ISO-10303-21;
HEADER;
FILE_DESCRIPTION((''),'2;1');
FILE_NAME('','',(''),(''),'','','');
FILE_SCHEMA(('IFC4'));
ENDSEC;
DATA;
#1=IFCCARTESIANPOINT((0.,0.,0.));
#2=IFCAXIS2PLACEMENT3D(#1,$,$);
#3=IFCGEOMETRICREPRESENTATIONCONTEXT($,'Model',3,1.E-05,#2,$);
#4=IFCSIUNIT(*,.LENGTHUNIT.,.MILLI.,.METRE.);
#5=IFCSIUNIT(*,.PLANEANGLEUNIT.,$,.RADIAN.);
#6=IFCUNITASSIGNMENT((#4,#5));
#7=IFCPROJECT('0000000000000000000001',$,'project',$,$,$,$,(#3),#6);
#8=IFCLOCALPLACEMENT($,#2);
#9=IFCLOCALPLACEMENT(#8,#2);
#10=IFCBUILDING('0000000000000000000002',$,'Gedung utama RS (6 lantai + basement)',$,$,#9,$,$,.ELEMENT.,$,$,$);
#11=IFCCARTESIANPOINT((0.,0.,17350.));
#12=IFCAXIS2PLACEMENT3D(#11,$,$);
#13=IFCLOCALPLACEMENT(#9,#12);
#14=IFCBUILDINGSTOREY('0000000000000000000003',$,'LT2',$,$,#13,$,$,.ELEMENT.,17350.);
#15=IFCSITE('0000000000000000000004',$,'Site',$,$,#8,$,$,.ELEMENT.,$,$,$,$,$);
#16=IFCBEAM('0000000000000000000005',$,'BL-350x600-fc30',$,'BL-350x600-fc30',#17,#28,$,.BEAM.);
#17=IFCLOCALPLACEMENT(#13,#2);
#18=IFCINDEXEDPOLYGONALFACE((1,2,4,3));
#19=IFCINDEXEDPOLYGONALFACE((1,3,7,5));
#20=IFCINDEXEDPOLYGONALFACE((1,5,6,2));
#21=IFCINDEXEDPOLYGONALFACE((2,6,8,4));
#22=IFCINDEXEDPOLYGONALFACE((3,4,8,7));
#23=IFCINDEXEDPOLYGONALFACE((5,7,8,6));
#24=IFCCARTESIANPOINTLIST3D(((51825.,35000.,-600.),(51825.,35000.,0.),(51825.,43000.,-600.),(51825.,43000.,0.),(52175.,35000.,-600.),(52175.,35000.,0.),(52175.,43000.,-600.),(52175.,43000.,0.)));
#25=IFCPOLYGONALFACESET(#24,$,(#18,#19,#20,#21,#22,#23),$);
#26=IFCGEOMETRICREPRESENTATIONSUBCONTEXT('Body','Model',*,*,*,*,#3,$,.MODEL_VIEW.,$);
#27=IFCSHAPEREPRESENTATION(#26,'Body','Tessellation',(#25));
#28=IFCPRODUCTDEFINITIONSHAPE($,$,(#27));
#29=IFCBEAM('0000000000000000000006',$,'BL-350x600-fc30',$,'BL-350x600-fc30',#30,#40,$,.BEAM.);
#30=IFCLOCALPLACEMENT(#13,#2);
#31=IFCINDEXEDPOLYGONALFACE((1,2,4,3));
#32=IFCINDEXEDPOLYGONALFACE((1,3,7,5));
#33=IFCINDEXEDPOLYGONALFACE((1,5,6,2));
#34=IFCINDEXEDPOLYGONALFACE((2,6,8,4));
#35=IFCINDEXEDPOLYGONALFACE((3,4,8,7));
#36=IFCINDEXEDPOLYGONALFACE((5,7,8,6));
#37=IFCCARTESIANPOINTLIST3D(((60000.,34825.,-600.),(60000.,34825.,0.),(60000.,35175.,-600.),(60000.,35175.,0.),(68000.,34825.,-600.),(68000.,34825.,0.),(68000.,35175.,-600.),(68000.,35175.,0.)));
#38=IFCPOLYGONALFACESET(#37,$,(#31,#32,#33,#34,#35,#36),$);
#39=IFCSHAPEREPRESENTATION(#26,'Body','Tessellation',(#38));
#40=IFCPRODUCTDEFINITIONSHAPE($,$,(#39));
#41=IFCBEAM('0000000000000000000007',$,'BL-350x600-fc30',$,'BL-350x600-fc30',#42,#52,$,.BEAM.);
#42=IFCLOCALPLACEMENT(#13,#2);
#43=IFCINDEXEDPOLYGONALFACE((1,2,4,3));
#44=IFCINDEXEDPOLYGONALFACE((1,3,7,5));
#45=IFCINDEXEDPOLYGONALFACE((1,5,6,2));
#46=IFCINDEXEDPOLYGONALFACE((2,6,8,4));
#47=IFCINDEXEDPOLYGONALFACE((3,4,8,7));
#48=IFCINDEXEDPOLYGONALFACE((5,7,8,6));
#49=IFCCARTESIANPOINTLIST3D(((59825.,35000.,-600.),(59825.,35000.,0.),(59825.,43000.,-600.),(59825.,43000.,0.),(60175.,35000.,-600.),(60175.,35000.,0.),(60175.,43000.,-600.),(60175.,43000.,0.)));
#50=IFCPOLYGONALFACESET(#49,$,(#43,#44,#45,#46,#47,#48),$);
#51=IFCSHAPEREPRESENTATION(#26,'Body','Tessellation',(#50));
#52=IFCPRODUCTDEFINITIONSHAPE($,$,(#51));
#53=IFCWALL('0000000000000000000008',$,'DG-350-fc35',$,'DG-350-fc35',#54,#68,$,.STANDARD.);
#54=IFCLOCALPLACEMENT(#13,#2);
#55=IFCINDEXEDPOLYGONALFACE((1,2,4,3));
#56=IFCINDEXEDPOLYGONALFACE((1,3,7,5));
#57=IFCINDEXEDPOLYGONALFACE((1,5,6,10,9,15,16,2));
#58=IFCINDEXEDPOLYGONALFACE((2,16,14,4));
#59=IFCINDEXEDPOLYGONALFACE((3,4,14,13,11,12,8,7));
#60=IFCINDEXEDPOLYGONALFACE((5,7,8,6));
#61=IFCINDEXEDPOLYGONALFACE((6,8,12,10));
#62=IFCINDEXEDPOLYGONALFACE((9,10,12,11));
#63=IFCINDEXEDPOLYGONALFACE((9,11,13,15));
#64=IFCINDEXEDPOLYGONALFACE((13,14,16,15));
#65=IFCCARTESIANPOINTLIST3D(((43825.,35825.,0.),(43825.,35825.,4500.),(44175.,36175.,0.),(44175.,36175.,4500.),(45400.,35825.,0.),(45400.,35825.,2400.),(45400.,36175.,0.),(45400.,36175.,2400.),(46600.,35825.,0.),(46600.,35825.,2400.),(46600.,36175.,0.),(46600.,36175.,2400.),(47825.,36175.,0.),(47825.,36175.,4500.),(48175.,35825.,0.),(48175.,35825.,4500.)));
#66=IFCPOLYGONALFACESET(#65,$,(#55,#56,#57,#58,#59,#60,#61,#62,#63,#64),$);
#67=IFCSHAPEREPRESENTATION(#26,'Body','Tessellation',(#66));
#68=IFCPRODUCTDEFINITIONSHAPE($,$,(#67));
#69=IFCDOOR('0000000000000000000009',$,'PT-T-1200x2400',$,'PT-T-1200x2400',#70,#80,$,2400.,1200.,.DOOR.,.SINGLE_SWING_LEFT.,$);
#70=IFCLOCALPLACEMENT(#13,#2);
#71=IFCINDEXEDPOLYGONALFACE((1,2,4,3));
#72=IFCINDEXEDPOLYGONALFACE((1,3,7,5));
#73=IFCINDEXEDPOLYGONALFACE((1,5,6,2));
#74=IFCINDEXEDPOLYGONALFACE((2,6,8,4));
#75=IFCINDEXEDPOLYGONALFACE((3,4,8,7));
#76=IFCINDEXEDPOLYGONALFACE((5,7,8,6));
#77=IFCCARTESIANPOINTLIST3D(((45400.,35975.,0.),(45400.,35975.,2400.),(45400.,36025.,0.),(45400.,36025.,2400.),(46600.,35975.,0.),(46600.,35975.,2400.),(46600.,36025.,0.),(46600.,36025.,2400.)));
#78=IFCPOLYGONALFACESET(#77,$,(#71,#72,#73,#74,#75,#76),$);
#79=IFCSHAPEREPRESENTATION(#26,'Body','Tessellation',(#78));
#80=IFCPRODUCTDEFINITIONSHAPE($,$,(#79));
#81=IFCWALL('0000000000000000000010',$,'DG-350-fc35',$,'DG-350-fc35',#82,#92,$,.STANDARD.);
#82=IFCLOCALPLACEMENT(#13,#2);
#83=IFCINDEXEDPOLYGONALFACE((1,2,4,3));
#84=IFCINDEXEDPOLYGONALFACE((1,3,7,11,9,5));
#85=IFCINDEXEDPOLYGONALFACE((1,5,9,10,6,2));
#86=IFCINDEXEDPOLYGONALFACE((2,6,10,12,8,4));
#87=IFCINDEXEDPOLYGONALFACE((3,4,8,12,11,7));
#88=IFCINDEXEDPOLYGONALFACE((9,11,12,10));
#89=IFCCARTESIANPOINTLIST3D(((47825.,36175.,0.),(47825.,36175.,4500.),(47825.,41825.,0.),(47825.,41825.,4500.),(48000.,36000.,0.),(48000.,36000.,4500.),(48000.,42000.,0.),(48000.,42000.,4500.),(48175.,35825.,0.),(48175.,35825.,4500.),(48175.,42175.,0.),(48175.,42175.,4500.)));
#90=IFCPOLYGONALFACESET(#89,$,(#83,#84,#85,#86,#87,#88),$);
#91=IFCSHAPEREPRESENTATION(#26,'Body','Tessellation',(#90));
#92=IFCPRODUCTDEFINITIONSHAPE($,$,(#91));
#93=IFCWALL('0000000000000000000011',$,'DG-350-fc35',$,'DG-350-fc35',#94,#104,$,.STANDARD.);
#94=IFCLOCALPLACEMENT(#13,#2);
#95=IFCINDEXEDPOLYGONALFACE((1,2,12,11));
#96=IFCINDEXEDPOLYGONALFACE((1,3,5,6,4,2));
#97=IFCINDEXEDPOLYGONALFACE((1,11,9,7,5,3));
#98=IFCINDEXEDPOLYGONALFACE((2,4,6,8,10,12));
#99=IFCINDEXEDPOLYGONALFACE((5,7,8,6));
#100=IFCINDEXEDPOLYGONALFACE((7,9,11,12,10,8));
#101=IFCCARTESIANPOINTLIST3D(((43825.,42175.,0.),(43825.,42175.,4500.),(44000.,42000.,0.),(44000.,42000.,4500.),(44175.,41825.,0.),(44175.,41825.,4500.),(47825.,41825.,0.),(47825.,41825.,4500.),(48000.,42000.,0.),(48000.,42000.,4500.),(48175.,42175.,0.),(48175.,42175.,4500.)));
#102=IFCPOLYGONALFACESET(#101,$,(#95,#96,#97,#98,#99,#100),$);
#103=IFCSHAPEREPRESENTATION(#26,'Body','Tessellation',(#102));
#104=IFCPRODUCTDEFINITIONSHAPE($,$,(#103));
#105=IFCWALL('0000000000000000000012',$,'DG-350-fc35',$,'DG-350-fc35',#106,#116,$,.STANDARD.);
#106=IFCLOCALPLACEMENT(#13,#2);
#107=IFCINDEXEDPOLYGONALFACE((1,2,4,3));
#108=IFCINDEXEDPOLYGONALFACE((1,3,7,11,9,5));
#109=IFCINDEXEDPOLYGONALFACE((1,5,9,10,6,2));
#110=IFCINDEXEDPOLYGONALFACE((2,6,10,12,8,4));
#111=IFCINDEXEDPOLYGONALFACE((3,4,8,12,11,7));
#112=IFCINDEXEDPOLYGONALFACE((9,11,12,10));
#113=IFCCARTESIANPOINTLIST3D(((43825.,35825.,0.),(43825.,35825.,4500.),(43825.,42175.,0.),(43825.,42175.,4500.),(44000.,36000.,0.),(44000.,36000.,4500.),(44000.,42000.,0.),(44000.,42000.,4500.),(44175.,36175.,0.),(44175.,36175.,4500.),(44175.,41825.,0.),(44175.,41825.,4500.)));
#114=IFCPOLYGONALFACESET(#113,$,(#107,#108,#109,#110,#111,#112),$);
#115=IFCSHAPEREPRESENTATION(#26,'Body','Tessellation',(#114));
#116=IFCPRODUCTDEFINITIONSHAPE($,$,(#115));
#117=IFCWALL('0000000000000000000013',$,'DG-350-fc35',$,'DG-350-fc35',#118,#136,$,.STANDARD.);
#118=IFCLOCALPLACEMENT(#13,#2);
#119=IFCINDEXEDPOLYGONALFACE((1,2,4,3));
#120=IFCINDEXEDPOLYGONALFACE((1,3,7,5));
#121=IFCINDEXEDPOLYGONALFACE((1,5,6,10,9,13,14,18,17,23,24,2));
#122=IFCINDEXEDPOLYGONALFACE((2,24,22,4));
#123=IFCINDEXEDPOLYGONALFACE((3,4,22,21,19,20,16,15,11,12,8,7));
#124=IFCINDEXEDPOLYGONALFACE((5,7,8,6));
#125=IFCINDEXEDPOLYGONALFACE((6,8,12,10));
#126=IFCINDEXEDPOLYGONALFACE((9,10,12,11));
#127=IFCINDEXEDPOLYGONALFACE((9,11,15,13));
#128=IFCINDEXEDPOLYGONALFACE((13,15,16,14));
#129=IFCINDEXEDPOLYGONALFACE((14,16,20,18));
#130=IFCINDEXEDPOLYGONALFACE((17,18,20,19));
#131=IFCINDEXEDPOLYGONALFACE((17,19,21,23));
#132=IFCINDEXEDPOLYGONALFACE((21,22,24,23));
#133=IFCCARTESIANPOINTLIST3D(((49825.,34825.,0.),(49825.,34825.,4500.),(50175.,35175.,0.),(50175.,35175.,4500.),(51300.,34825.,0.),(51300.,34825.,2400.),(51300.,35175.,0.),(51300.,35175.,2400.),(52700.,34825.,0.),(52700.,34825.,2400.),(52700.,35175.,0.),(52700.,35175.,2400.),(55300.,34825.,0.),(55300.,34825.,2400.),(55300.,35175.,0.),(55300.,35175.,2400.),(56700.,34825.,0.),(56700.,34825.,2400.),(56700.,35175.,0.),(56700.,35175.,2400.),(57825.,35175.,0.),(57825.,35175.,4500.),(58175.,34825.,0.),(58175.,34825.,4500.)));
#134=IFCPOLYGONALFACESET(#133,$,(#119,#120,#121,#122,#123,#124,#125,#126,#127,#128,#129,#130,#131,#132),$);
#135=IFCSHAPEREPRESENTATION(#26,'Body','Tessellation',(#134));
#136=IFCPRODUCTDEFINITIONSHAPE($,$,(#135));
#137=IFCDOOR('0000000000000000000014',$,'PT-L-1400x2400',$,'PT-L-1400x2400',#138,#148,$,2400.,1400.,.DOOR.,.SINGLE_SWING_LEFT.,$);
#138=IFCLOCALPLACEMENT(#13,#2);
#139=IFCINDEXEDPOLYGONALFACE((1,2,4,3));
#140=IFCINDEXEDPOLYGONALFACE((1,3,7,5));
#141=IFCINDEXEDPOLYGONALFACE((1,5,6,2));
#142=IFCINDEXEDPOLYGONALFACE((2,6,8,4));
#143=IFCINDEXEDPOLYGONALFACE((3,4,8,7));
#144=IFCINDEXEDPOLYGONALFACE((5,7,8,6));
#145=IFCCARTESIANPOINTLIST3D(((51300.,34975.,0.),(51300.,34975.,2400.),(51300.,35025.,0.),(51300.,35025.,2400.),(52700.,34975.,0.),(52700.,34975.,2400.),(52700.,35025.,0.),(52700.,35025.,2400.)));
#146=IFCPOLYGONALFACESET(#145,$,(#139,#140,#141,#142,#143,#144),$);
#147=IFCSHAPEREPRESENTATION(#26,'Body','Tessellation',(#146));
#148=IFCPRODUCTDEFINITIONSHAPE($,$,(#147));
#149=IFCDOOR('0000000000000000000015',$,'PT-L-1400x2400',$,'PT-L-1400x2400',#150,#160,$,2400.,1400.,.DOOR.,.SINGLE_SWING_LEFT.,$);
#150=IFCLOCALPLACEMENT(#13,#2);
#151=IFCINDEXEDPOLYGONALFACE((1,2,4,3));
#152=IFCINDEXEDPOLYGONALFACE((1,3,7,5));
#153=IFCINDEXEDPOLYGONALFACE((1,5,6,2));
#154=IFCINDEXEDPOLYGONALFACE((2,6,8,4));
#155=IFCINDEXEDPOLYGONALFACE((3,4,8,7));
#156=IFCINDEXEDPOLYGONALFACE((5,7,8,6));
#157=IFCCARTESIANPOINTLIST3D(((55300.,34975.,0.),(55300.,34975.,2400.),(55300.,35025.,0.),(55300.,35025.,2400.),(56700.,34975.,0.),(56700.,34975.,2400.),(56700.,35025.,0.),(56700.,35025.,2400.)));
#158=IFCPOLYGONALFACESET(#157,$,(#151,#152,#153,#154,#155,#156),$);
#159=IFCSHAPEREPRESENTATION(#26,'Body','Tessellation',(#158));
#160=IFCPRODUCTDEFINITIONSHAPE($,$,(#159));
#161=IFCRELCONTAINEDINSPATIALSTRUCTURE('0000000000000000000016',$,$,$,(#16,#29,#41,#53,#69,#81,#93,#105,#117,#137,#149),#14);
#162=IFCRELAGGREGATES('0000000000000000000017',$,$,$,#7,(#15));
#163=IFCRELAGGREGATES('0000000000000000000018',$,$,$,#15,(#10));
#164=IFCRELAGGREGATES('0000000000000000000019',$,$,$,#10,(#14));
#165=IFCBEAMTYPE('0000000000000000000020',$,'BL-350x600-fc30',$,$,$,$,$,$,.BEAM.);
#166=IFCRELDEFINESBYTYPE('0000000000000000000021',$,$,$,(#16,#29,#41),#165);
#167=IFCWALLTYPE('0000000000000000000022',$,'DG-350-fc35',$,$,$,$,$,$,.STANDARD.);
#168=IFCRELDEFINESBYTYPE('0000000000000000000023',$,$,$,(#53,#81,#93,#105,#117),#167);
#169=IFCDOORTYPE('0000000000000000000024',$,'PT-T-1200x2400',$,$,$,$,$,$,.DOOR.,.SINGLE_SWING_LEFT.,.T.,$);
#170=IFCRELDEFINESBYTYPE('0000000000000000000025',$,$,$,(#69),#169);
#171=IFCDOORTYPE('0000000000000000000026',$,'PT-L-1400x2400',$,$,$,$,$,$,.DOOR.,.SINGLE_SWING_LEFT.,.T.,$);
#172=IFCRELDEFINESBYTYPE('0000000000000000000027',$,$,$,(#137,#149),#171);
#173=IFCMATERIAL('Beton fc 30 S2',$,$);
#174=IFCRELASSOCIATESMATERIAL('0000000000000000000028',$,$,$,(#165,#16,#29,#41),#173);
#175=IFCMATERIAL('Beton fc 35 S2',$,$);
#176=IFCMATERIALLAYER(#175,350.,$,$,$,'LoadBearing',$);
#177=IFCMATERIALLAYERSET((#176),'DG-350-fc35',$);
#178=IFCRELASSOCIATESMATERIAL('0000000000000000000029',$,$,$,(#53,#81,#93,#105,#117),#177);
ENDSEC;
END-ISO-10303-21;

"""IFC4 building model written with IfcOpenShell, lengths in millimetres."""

from ifc_helpers import new_model, si_unit, frame, frame_2d, origin, origin_2d, place, context, subcontext, project, spatial, polyline, rectangle, outline, extrude, material, layer, layer_set, layer_usage, material_profile, profile_set, profile_usage, type_object, element, fill, save


model = new_model("IFC4")

# Units and contexts
model_context = context("Model", 3, precision=1e-05, world=origin())
body_context = subcontext(model_context, "Body", "Model", "MODEL_VIEW")
ifc_project = project(units=[si_unit("LENGTHUNIT", "METRE", prefix="MILLI"), si_unit("PLANEANGLEUNIT", "RADIAN")], contexts=[model_context])

# Site, building, storey
site_placement = place(None, origin())
site = spatial("IfcSite", under=ifc_project, at=site_placement, Name="Site", CompositionType="ELEMENT")
building_placement = place(site_placement, origin())
building = spatial("IfcBuilding", under=site, at=building_placement, Name="Gedung utama RS (6 lantai + basement)", CompositionType="ELEMENT")
storey_placement = place(building_placement, frame((0.0, 0.0, 17350.0)))
storey = spatial("IfcBuildingStorey", under=building, at=storey_placement, Name="LT2", CompositionType="ELEMENT", Elevation=17350.0)

# Beams
ifc_material_1 = material(Name="Beton fc 30 S2")
ifc_material_profile_1 = material_profile(ifc_material_1, rectangle(XDim=350.0, YDim=600.0, at=origin_2d()), Name="BL-350x600-fc30")
ifc_profile_set_1 = profile_set([ifc_material_profile_1], Name="BL-350x600-fc30")
ifc_profile_usage_1 = profile_usage(ifc_profile_set_1, cardinal=8)
beam_type = type_object("IfcBeamType", Name="BL-350x600-fc30", PredefinedType="BEAM", material=ifc_profile_set_1)
beam_1_placement = place(storey_placement, frame((52000.0, 35000.0, -300.0)))
element("IfcBeam", 1, at=beam_1_placement, inside=storey, type_object=beam_type, material=ifc_profile_usage_1, Name="BL-350x600-fc30", ObjectType="BL-350x600-fc30", PredefinedType="BEAM", context=body_context, shape_type="SweptSolid", body=[
    extrude(rectangle(XDim=350.0, YDim=600.0, at=origin_2d()), frame((0.0, 0.0, 0.0), z_axis=(0.0, 1.0, 0.0), x_axis=(-1.0, 0.0, 0.0)), (0.0, 0.0, 1.0), 8000.0),
])
beam_2_placement = place(storey_placement, frame((60000.0, 35000.0, -300.0)))
element("IfcBeam", 2, at=beam_2_placement, inside=storey, type_object=beam_type, material=ifc_profile_usage_1, Name="BL-350x600-fc30", ObjectType="BL-350x600-fc30", PredefinedType="BEAM", context=body_context, shape_type="SweptSolid", body=[
    extrude(rectangle(XDim=350.0, YDim=600.0, at=origin_2d()), frame((0.0, 0.0, 0.0), z_axis=(1.0, 0.0, 0.0), x_axis=(0.0, 1.0, 0.0)), (0.0, 0.0, 1.0), 8000.0),
])
beam_3_placement = place(storey_placement, frame((60000.0, 35000.0, -300.0)))
element("IfcBeam", 3, at=beam_3_placement, inside=storey, type_object=beam_type, material=ifc_profile_usage_1, Name="BL-350x600-fc30", ObjectType="BL-350x600-fc30", PredefinedType="BEAM", context=body_context, shape_type="SweptSolid", body=[
    extrude(rectangle(XDim=350.0, YDim=600.0, at=origin_2d()), frame((0.0, 0.0, 0.0), z_axis=(0.0, 1.0, 0.0), x_axis=(-1.0, 0.0, 0.0)), (0.0, 0.0, 1.0), 8000.0),
])

# Wall, opening, door
ifc_material_2 = material(Name="Beton fc 35 S2")
ifc_layer = layer(ifc_material_2, 350.0, Category="LoadBearing")
ifc_layer_set = layer_set([ifc_layer], Name="DG-350-fc35")
ifc_layer_usage = layer_usage(ifc_layer_set, "AXIS2", "NEGATIVE", 175.0)
wall_type = type_object("IfcWallType", Name="DG-350-fc35", PredefinedType="STANDARD")
wall_1_placement = place(storey_placement, frame((44000.0, 36000.0, 0.0), z_axis=(0.0, 0.0, 1.0), x_axis=(1.0, 0.0, 0.0)))
wall_1 = element("IfcWall", 4, at=wall_1_placement, inside=storey, type_object=wall_type, material=ifc_layer_usage, Name="DG-350-fc35", ObjectType="DG-350-fc35", PredefinedType="STANDARD", context=body_context, shape_type="SweptSolid", body=[
    extrude(outline(polyline([(-175.0, -175.0), (0.0, 0.0), (175.0, 175.0), (3825.0, 175.0), (4000.0, 0.0), (4175.0, -175.0), (-175.0, -175.0)])), origin(), (0.0, 0.0, 1.0), 4500.0),
])
opening_1_placement = place(wall_1_placement, frame((1400.0, 0.0, 0.0), z_axis=(0.0, 0.0, 1.0), x_axis=(1.0, 0.0, 0.0)))
opening_1 = element("IfcOpeningElement", 5, at=opening_1_placement, cuts=wall_1, PredefinedType="OPENING", context=body_context, shape_type="SweptSolid", body=[
    extrude(rectangle(XDim=1200.0, YDim=370.0, at=frame_2d((600.0, 0.0))), origin(), (0.0, 0.0, 1.0), 2400.0),
])
door_type_1 = type_object("IfcDoorType", Name="PT-T-1200x2400", OperationType="SINGLE_SWING_LEFT", ParameterTakesPrecedence=True, PredefinedType="DOOR")
door_1_placement = place(opening_1_placement, origin())
door_1 = element("IfcDoor", 6, at=door_1_placement, inside=storey, type_object=door_type_1, Name="PT-T-1200x2400", ObjectType="PT-T-1200x2400", OperationType="SINGLE_SWING_LEFT", OverallHeight=2400.0, OverallWidth=1200.0, PredefinedType="DOOR", context=body_context, shape_type="SweptSolid", body=[
    extrude(rectangle(XDim=1200.0, YDim=50.0, at=frame_2d((600.0, 0.0))), origin(), (0.0, 0.0, 1.0), 2400.0),
])
fill(opening_1, door_1)

# Walls
wall_2_placement = place(storey_placement, frame((48000.0, 36000.0, 0.0), z_axis=(0.0, 0.0, 1.0), x_axis=(0.0, 1.0, 0.0)))
element("IfcWall", 7, at=wall_2_placement, inside=storey, type_object=wall_type, material=ifc_layer_usage, Name="DG-350-fc35", ObjectType="DG-350-fc35", PredefinedType="STANDARD", context=body_context, shape_type="SweptSolid", body=[
    extrude(outline(polyline([(-175.0, -175.0), (0.0, 0.0), (175.0, 175.0), (5825.0, 175.0), (6000.0, 0.0), (6175.0, -175.0), (-175.0, -175.0)])), origin(), (0.0, 0.0, 1.0), 4500.0),
])
wall_3_placement = place(storey_placement, frame((48000.0, 42000.0, 0.0), z_axis=(0.0, 0.0, 1.0), x_axis=(-1.0, 0.0, 0.0)))
element("IfcWall", 8, at=wall_3_placement, inside=storey, type_object=wall_type, material=ifc_layer_usage, Name="DG-350-fc35", ObjectType="DG-350-fc35", PredefinedType="STANDARD", context=body_context, shape_type="SweptSolid", body=[
    extrude(outline(polyline([(-175.0, -175.0), (0.0, 0.0), (175.0, 175.0), (3825.0, 175.0), (4000.0, 0.0), (4175.0, -175.0), (-175.0, -175.0)])), origin(), (0.0, 0.0, 1.0), 4500.0),
])
wall_4_placement = place(storey_placement, frame((44000.0, 42000.0, 0.0), z_axis=(0.0, 0.0, 1.0), x_axis=(0.0, -1.0, 0.0)))
element("IfcWall", 9, at=wall_4_placement, inside=storey, type_object=wall_type, material=ifc_layer_usage, Name="DG-350-fc35", ObjectType="DG-350-fc35", PredefinedType="STANDARD", context=body_context, shape_type="SweptSolid", body=[
    extrude(outline(polyline([(-175.0, -175.0), (0.0, 0.0), (175.0, 175.0), (5825.0, 175.0), (6000.0, 0.0), (6175.0, -175.0), (-175.0, -175.0)])), origin(), (0.0, 0.0, 1.0), 4500.0),
])

# Wall, openings, doors
wall_5_placement = place(storey_placement, frame((50000.0, 35000.0, 0.0), z_axis=(0.0, 0.0, 1.0), x_axis=(1.0, 0.0, 0.0)))
wall_5 = element("IfcWall", 10, at=wall_5_placement, inside=storey, type_object=wall_type, material=ifc_layer_usage, Name="DG-350-fc35", ObjectType="DG-350-fc35", PredefinedType="STANDARD", context=body_context, shape_type="SweptSolid", body=[
    extrude(outline(polyline([(-175.0, -175.0), (0.0, 0.0), (175.0, 175.0), (7825.0, 175.0), (8000.0, 0.0), (8175.0, -175.0), (-175.0, -175.0)])), origin(), (0.0, 0.0, 1.0), 4500.0),
])
opening_2_placement = place(wall_5_placement, frame((1300.0, 0.0, 0.0), z_axis=(0.0, 0.0, 1.0), x_axis=(1.0, 0.0, 0.0)))
opening_2 = element("IfcOpeningElement", 11, at=opening_2_placement, cuts=wall_5, PredefinedType="OPENING", context=body_context, shape_type="SweptSolid", body=[
    extrude(rectangle(XDim=1400.0, YDim=370.0, at=frame_2d((700.0, 0.0))), origin(), (0.0, 0.0, 1.0), 2400.0),
])
opening_3_placement = place(wall_5_placement, frame((5300.0, 0.0, 0.0), z_axis=(0.0, 0.0, 1.0), x_axis=(1.0, 0.0, 0.0)))
opening_3 = element("IfcOpeningElement", 12, at=opening_3_placement, cuts=wall_5, PredefinedType="OPENING", context=body_context, shape_type="SweptSolid", body=[
    extrude(rectangle(XDim=1400.0, YDim=370.0, at=frame_2d((700.0, 0.0))), origin(), (0.0, 0.0, 1.0), 2400.0),
])
door_type_2 = type_object("IfcDoorType", Name="PT-L-1400x2400", OperationType="SINGLE_SWING_LEFT", ParameterTakesPrecedence=True, PredefinedType="DOOR")
door_2_placement = place(opening_2_placement, origin())
door_2 = element("IfcDoor", 13, at=door_2_placement, inside=storey, type_object=door_type_2, Name="PT-L-1400x2400", ObjectType="PT-L-1400x2400", OperationType="SINGLE_SWING_LEFT", OverallHeight=2400.0, OverallWidth=1400.0, PredefinedType="DOOR", context=body_context, shape_type="SweptSolid", body=[
    extrude(rectangle(XDim=1400.0, YDim=50.0, at=frame_2d((700.0, 0.0))), origin(), (0.0, 0.0, 1.0), 2400.0),
])
fill(opening_2, door_2)
door_3_placement = place(opening_3_placement, origin())
door_3 = element("IfcDoor", 14, at=door_3_placement, inside=storey, type_object=door_type_2, Name="PT-L-1400x2400", ObjectType="PT-L-1400x2400", OperationType="SINGLE_SWING_LEFT", OverallHeight=2400.0, OverallWidth=1400.0, PredefinedType="DOOR", context=body_context, shape_type="SweptSolid", body=[
    extrude(rectangle(XDim=1400.0, YDim=50.0, at=frame_2d((700.0, 0.0))), origin(), (0.0, 0.0, 1.0), 2400.0),
])
fill(opening_3, door_3)

save(model, "model.ifc")
